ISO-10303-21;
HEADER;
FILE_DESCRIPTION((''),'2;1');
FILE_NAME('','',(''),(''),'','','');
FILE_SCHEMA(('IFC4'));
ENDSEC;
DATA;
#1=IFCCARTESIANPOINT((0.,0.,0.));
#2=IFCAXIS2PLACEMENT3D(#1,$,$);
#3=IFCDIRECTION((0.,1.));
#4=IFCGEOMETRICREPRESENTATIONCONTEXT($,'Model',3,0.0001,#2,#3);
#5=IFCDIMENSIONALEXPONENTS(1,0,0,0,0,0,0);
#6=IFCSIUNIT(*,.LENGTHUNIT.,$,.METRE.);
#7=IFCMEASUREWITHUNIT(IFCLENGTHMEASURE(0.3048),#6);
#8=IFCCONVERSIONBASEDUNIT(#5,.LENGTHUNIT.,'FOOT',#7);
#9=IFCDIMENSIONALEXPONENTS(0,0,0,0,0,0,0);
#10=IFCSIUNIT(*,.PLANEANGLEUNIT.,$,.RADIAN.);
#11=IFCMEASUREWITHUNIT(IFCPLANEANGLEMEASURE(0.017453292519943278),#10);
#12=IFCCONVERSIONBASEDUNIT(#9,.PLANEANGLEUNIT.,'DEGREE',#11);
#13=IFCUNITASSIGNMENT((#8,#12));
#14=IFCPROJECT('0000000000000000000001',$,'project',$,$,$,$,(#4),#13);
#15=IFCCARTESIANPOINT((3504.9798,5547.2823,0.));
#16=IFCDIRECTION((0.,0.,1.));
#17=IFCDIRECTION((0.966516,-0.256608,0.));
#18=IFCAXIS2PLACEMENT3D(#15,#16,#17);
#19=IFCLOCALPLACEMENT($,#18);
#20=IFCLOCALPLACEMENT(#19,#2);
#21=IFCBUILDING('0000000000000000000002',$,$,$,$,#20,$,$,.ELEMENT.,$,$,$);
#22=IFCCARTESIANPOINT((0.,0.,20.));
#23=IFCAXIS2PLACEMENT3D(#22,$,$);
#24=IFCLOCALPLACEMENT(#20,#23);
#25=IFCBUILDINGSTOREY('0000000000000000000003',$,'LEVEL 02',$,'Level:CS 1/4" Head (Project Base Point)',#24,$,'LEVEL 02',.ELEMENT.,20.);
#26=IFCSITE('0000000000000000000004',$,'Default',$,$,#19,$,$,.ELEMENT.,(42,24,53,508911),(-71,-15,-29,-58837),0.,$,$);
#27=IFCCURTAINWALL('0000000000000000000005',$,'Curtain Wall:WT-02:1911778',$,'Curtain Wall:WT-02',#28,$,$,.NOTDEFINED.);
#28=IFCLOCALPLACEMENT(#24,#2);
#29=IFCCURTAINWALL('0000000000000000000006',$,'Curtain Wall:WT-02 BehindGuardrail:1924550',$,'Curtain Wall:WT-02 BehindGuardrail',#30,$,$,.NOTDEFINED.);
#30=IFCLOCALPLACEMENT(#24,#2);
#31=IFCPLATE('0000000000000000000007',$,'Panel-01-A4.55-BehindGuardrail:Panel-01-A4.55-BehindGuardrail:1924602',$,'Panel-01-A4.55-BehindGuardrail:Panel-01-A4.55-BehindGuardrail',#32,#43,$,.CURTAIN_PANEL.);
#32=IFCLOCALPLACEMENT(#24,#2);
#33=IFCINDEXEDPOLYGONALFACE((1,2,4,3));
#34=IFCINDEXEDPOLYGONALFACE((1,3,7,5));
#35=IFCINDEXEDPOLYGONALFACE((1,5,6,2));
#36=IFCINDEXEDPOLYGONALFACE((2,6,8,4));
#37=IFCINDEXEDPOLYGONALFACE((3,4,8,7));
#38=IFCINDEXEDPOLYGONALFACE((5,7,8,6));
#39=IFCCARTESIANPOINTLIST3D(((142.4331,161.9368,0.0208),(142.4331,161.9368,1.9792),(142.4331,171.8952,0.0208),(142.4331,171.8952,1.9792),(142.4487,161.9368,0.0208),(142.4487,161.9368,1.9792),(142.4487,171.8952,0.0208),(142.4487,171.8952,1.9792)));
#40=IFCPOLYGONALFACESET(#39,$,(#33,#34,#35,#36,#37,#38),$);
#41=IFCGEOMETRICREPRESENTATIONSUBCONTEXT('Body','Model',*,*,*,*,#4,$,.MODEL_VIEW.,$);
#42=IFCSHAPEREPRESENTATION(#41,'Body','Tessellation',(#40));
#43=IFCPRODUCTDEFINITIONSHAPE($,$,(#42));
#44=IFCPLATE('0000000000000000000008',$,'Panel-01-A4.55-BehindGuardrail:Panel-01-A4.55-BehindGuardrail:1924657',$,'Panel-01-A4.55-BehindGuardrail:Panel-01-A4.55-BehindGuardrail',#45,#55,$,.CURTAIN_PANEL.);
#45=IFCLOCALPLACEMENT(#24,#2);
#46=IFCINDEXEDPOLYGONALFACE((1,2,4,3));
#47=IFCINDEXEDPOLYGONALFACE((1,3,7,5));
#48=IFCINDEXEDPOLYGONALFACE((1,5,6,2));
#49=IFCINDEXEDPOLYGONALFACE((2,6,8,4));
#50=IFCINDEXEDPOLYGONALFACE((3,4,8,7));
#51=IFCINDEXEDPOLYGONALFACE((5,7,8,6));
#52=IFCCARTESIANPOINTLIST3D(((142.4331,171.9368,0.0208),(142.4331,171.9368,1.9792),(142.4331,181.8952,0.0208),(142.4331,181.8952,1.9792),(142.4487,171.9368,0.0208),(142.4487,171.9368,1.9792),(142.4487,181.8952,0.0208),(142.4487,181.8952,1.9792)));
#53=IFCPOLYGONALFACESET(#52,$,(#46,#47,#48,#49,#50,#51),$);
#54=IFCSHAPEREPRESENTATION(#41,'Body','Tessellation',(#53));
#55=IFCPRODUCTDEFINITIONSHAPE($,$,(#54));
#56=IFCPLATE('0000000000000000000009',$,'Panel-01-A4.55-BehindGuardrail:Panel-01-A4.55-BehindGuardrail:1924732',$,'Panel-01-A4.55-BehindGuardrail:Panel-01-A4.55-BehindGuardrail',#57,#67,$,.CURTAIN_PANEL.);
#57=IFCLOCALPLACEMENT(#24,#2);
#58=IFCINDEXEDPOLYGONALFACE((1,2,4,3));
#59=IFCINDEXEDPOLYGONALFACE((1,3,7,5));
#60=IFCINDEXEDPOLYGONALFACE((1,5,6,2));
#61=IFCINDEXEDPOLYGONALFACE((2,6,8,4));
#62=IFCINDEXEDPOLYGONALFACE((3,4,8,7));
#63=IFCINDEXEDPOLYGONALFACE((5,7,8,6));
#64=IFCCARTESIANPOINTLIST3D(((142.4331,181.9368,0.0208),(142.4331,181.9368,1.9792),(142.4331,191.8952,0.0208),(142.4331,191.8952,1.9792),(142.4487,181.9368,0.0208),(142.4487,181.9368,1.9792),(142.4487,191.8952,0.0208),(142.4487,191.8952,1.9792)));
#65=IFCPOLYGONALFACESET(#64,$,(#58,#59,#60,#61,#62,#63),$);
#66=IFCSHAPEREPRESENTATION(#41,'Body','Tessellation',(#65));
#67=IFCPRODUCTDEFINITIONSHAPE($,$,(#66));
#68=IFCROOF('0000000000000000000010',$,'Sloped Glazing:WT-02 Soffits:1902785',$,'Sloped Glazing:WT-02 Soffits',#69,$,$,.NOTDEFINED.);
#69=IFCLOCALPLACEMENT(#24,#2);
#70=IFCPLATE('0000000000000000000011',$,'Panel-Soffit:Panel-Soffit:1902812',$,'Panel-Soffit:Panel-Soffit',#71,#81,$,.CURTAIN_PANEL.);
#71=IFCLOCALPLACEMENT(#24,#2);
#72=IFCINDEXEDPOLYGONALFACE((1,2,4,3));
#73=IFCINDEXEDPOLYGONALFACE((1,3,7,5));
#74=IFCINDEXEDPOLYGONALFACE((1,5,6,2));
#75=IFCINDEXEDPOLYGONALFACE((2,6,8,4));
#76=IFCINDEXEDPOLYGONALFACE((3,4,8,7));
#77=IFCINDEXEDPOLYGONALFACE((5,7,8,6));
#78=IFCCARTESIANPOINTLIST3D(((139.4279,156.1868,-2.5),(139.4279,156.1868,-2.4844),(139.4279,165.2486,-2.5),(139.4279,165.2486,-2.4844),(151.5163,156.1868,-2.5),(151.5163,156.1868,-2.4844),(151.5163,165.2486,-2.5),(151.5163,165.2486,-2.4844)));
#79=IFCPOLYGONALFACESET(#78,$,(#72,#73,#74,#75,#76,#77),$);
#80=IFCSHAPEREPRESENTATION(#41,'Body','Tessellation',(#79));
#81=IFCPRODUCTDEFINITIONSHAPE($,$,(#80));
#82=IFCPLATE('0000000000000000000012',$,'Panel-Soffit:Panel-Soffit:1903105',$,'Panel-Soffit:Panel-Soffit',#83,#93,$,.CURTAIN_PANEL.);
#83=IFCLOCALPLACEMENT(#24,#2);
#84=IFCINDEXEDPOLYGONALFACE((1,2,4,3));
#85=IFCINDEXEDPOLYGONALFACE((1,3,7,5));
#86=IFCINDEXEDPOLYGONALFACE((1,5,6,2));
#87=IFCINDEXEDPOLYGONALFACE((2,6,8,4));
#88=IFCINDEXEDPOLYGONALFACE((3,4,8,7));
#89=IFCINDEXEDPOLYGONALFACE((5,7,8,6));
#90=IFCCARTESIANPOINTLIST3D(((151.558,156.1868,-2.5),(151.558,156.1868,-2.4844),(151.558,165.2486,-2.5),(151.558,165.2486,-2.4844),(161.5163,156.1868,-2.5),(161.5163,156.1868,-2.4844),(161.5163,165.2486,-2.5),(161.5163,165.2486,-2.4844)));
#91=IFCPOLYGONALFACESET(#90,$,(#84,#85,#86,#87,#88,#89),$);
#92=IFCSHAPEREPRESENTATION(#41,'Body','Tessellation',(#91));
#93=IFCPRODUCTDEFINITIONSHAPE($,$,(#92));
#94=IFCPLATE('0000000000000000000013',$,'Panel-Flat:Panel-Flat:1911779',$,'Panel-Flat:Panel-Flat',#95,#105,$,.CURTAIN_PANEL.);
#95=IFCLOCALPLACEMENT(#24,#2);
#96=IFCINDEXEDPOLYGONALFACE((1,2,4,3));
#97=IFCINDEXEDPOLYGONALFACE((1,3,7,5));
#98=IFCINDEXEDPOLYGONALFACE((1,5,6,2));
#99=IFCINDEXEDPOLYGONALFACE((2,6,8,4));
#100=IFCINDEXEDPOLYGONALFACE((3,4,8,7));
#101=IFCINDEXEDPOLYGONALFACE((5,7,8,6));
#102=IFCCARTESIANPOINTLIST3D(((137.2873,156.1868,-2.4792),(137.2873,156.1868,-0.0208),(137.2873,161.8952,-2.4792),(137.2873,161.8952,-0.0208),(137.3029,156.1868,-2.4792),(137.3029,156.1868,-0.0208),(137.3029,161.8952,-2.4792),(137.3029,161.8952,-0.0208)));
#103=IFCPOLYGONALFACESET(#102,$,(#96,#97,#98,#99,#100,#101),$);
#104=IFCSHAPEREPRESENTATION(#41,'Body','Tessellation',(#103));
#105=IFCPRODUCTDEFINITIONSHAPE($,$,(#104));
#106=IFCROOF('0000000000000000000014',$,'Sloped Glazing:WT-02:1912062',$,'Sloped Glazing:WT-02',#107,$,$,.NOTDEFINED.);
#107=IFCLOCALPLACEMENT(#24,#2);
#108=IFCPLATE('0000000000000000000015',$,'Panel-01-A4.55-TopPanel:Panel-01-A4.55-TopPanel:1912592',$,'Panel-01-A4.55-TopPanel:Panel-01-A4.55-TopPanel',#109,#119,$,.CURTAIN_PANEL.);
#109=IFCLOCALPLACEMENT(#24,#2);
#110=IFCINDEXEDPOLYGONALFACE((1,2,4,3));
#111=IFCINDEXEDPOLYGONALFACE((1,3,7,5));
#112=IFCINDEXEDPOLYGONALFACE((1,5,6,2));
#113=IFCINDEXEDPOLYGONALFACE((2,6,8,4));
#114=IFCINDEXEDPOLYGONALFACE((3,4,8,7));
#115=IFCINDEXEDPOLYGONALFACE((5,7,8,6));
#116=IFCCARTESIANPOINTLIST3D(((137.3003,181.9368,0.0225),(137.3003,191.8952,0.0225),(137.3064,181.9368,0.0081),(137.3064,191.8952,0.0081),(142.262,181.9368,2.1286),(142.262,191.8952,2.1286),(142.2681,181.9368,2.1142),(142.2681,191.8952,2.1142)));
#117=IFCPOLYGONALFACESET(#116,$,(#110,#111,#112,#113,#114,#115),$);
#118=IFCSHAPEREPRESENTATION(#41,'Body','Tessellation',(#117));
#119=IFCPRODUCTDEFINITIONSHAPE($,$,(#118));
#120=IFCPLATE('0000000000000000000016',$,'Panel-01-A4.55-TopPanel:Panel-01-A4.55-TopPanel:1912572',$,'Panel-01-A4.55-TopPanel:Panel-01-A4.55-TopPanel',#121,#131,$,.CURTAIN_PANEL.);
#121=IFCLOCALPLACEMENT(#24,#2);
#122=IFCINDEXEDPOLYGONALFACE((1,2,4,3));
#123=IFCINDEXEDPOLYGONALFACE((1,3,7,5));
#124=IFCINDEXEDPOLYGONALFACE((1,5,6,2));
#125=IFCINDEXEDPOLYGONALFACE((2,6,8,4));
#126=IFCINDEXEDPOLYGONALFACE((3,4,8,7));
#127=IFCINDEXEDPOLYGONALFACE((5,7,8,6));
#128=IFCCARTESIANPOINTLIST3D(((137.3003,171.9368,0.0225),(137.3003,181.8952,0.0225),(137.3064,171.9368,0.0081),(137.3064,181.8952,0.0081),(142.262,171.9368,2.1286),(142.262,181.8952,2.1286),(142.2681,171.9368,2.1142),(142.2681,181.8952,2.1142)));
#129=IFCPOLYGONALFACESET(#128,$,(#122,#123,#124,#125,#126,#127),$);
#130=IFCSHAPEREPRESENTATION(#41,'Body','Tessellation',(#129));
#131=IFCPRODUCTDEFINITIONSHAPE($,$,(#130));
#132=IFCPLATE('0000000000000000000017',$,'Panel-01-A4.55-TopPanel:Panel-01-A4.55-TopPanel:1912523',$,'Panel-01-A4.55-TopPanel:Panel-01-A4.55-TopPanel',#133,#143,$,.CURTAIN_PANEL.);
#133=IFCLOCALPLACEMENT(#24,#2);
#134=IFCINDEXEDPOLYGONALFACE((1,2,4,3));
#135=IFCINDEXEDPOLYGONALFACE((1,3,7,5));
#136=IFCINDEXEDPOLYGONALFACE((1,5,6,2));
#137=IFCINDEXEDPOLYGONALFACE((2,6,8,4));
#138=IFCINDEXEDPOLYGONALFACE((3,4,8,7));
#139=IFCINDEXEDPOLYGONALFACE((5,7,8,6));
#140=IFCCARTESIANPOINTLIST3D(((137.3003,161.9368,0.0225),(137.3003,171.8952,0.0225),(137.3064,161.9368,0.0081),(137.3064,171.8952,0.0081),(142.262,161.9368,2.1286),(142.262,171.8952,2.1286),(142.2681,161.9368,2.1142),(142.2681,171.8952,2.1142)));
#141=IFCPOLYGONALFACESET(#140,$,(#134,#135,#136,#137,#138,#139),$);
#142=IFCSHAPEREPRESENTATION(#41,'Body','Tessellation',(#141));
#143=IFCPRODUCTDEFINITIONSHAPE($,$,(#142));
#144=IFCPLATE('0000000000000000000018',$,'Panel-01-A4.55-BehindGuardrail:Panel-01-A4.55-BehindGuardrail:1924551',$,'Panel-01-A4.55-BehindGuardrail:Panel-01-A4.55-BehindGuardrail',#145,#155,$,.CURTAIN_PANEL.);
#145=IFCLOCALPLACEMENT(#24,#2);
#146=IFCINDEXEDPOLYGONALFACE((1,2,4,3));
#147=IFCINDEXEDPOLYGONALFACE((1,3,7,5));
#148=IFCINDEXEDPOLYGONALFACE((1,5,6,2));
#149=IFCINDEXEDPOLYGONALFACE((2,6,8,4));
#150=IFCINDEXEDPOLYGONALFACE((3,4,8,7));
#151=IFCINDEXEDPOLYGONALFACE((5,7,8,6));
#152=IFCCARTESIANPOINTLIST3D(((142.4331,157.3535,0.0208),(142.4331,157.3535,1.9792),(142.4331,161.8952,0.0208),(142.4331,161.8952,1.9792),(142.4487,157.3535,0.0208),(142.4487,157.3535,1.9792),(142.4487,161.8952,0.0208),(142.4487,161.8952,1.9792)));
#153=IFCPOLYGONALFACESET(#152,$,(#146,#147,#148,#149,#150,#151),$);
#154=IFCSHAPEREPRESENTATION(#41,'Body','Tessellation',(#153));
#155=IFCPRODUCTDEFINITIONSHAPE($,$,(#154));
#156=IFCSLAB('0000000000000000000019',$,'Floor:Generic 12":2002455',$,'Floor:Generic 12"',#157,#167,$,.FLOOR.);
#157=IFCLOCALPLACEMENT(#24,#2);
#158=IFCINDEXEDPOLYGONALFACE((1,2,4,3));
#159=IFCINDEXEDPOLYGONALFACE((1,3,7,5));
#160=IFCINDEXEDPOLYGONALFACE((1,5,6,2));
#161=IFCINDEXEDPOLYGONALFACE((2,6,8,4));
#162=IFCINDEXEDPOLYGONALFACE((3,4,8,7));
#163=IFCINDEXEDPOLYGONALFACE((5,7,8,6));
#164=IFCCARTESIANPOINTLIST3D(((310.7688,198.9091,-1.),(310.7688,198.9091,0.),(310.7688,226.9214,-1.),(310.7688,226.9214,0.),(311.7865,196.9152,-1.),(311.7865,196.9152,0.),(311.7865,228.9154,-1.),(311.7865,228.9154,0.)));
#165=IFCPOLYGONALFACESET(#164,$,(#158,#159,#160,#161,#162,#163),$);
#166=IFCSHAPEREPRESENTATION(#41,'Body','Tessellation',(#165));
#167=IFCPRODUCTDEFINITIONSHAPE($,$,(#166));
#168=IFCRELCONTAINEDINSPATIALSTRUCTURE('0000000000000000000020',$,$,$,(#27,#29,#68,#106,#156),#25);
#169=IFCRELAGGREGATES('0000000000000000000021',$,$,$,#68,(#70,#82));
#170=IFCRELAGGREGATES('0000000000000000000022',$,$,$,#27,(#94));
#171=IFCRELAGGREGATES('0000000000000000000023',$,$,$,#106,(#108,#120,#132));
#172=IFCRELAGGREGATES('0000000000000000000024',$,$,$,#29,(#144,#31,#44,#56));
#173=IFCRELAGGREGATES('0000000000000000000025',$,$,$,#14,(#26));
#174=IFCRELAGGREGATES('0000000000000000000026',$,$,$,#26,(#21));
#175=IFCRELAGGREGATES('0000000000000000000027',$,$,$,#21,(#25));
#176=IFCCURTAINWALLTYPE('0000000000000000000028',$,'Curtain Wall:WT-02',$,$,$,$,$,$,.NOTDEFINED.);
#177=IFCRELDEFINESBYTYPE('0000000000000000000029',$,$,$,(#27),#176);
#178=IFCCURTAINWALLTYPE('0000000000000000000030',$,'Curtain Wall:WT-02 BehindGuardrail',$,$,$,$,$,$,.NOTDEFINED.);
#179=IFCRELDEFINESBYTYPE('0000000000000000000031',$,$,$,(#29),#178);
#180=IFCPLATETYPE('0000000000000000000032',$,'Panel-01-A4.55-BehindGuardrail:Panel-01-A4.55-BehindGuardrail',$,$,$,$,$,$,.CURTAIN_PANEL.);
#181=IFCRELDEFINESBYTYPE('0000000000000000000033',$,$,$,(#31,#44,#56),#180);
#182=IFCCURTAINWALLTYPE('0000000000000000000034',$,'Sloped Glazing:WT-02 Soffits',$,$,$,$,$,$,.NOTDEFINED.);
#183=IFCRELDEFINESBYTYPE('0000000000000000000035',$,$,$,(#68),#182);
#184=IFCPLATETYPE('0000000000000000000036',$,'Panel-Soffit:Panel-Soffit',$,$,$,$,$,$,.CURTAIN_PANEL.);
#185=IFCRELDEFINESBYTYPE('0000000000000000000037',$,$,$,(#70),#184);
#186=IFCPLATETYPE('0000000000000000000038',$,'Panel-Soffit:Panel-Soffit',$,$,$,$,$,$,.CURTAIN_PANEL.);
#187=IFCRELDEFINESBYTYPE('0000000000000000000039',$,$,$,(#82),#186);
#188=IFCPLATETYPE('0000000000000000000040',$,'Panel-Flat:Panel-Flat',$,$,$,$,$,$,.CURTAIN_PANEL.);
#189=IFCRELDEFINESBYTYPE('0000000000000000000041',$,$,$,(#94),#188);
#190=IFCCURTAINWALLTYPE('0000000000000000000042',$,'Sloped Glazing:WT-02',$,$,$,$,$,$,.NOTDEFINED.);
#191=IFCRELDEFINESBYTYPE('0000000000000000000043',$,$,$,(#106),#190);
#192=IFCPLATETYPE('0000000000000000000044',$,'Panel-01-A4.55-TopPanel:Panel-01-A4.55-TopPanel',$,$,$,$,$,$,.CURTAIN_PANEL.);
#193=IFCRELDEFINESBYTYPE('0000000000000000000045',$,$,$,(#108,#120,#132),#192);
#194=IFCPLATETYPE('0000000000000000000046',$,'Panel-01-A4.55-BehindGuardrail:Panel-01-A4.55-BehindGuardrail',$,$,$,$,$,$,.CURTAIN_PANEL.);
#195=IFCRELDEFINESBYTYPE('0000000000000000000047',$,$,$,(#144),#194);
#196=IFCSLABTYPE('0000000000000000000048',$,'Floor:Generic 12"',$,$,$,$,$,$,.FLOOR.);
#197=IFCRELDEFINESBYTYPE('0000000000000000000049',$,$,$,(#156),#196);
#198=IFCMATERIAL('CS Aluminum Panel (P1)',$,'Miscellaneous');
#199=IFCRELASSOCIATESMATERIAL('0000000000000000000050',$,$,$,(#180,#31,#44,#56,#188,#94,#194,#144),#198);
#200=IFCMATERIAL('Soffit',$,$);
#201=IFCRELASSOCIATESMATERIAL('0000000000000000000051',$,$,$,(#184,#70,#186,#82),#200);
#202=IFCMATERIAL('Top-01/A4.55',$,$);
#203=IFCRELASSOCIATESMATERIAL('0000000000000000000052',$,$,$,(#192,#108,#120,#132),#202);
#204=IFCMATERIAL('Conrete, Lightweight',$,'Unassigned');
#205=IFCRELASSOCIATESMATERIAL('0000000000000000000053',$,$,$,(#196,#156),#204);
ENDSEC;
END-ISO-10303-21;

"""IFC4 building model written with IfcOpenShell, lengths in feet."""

from ifc_helpers import new_model, entity, si_unit, converted_unit, direction, frame, origin, place, context, subcontext, project, spatial, indexed_curve, outline, extrude, source, transform, mapped, material, type_object, type_shapes, element, aggregate, save


model = new_model("IFC4")

# Units and contexts
model_context = context("Model", 3, precision=0.0001, world=origin(), true_north=direction((0.0, 1.0)))
body_context = subcontext(model_context, "Body", "Model", "MODEL_VIEW")
ifc_project = project(units=[converted_unit("LENGTHUNIT", "FOOT", entity("IfcLengthMeasure", 0.3048), si_unit("LENGTHUNIT", "METRE"), dimensions=[1, 0, 0, 0, 0, 0, 0]), converted_unit("PLANEANGLEUNIT", "DEGREE", entity("IfcPlaneAngleMeasure", 0.017453292519943278), si_unit("PLANEANGLEUNIT", "RADIAN"), dimensions=[0, 0, 0, 0, 0, 0, 0])], contexts=[model_context])

# Site, building, storey
site_placement = place(None, frame((3504.9798, 5547.2823, 0.0), z_axis=(0.0, 0.0, 1.0), x_axis=(0.966516, -0.256608, 0.0)))
site = spatial("IfcSite", under=ifc_project, at=site_placement, Name="Default", CompositionType="ELEMENT", RefLatitude=(42, 24, 53, 508911), RefLongitude=(-71, -15, -29, -58837), RefElevation=0.0)
building_placement = place(site_placement, origin())
building = spatial("IfcBuilding", under=site, at=building_placement, CompositionType="ELEMENT")
storey_placement = place(building_placement, frame((0.0, 0.0, 20.0)))
storey = spatial("IfcBuildingStorey", under=building, at=storey_placement, Name="LEVEL 02", ObjectType="Level:CS 1/4\" Head (Project Base Point)", LongName="LEVEL 02", CompositionType="ELEMENT", Elevation=20.0)

# Curtain wall
curtain_wall_type_1 = type_object("IfcCurtainWallType", Name="Curtain Wall:WT-02", PredefinedType="NOTDEFINED")
ifc_material_1 = material(Name="CS Aluminum Panel (P1)", Category="Miscellaneous")
curtain_wall_1_placement = place(storey_placement, frame((0.0, 0.0, -20.0)))
curtain_wall_1 = element("IfcCurtainWall", 1, at=curtain_wall_1_placement, inside=storey, type_object=curtain_wall_type_1, Name="Curtain Wall:WT-02:1911778", ObjectType="Curtain Wall:WT-02", PredefinedType="NOTDEFINED")

# Curtain wall, plates
ifc_material_2 = material(Name="Top-01/A4.55")
curtain_wall_type_2 = type_object("IfcCurtainWallType", Name="Curtain Wall:WT-02 BehindGuardrail", PredefinedType="NOTDEFINED")
plate_type_1 = type_object("IfcPlateType", Name="Panel-01-A4.55-BehindGuardrail:Panel-01-A4.55-BehindGuardrail", PredefinedType="CURTAIN_PANEL", material=ifc_material_1)
shared_shape_1 = source(origin(), body_context, "Body", "SweptSolid", [
    extrude(outline(indexed_curve([(-0.0078, -4.9792), (0.0078, -4.9792), (0.0078, 4.9792), (-0.0078, 4.9792), (-0.0078, -4.9792)], self_intersect=False)), frame((0.0, -0.0078, 0.0208), z_axis=(0.0, 0.0, 1.0), x_axis=(0.0, -1.0, 0.0)), (0.0, 0.0, 1.0), 1.9583),
])
type_shapes(plate_type_1, [shared_shape_1])
curtain_wall_2_placement = place(storey_placement, frame((0.0, 0.0, -20.0)))
curtain_wall_2 = element("IfcCurtainWall", 2, at=curtain_wall_2_placement, inside=storey, type_object=curtain_wall_type_2, Name="Curtain Wall:WT-02 BehindGuardrail:1924550", ObjectType="Curtain Wall:WT-02 BehindGuardrail", PredefinedType="NOTDEFINED")
plate_1_placement = place(curtain_wall_2_placement, frame((142.4331, 166.916, 20.0), z_axis=(0.0, 0.0, 1.0), x_axis=(0.0, 1.0, 0.0)))
plate_1 = element("IfcPlate", 3, at=plate_1_placement, type_object=plate_type_1, material=ifc_material_1, Name="Panel-01-A4.55-BehindGuardrail:Panel-01-A4.55-BehindGuardrail:1924602", ObjectType="Panel-01-A4.55-BehindGuardrail:Panel-01-A4.55-BehindGuardrail", PredefinedType="CURTAIN_PANEL", context=body_context, shape_type="MappedRepresentation", body=[
    mapped(shared_shape_1, transform((0.0, 0.0, 0.0), scale=1.0)),
])
plate_2_placement = place(curtain_wall_2_placement, frame((142.4331, 176.916, 20.0), z_axis=(0.0, 0.0, 1.0), x_axis=(0.0, 1.0, 0.0)))
plate_2 = element("IfcPlate", 4, at=plate_2_placement, type_object=plate_type_1, material=ifc_material_1, Name="Panel-01-A4.55-BehindGuardrail:Panel-01-A4.55-BehindGuardrail:1924657", ObjectType="Panel-01-A4.55-BehindGuardrail:Panel-01-A4.55-BehindGuardrail", PredefinedType="CURTAIN_PANEL", context=body_context, shape_type="MappedRepresentation", body=[
    mapped(shared_shape_1, transform((0.0, 0.0, 0.0), scale=1.0)),
])
plate_3_placement = place(curtain_wall_2_placement, frame((142.4331, 186.916, 20.0), z_axis=(0.0, 0.0, 1.0), x_axis=(0.0, 1.0, 0.0)))
plate_3 = element("IfcPlate", 5, at=plate_3_placement, type_object=plate_type_1, material=ifc_material_1, Name="Panel-01-A4.55-BehindGuardrail:Panel-01-A4.55-BehindGuardrail:1924732", ObjectType="Panel-01-A4.55-BehindGuardrail:Panel-01-A4.55-BehindGuardrail", PredefinedType="CURTAIN_PANEL", context=body_context, shape_type="MappedRepresentation", body=[
    mapped(shared_shape_1, transform((0.0, 0.0, 0.0), scale=1.0)),
])

# Roof, plates
curtain_wall_type_3 = type_object("IfcCurtainWallType", Name="Sloped Glazing:WT-02 Soffits", PredefinedType="NOTDEFINED")
roof_1_placement = place(storey_placement, frame((0.0, 0.0, -20.0)))
roof_1 = element("IfcRoof", 6, at=roof_1_placement, inside=storey, type_object=curtain_wall_type_3, Name="Sloped Glazing:WT-02 Soffits:1902785", ObjectType="Sloped Glazing:WT-02 Soffits", PredefinedType="NOTDEFINED")
ifc_material_3 = material(Name="Soffit")
plate_type_2 = type_object("IfcPlateType", Name="Panel-Soffit:Panel-Soffit", PredefinedType="CURTAIN_PANEL", material=ifc_material_3)
shared_shape_2 = source(origin(), body_context, "Body", "SweptSolid", [
    extrude(outline(indexed_curve([(-0.0078, -6.0442), (0.0078, -6.0442), (0.0078, 6.0442), (-0.0078, 6.0442), (-0.0078, -6.0442)], self_intersect=False)), frame((0.0, -0.0078, 0.0208), z_axis=(0.0, 0.0, 1.0), x_axis=(0.0, -1.0, 0.0)), (0.0, 0.0, 1.0), 9.0617),
])
type_shapes(plate_type_2, [shared_shape_2])
plate_4_placement = place(roof_1_placement, frame((145.4721, 156.166, 17.5), z_axis=(0.0, 1.0, 0.0), x_axis=(1.0, 0.0, 0.0)))
plate_4 = element("IfcPlate", 7, at=plate_4_placement, type_object=plate_type_2, material=ifc_material_3, Name="Panel-Soffit:Panel-Soffit:1902812", ObjectType="Panel-Soffit:Panel-Soffit", PredefinedType="CURTAIN_PANEL", context=body_context, shape_type="MappedRepresentation", body=[
    mapped(shared_shape_2, transform((0.0, 0.0, 0.0), scale=1.0)),
])
plate_type_3 = type_object("IfcPlateType", Name="Panel-Soffit:Panel-Soffit", PredefinedType="CURTAIN_PANEL", material=ifc_material_3)
shared_shape_3 = source(origin(), body_context, "Body", "SweptSolid", [
    extrude(outline(indexed_curve([(-0.0078, -4.9792), (0.0078, -4.9792), (0.0078, 4.9792), (-0.0078, 4.9792), (-0.0078, -4.9792)], self_intersect=False)), frame((0.0, -0.0078, 0.0208), z_axis=(0.0, 0.0, 1.0), x_axis=(0.0, -1.0, 0.0)), (0.0, 0.0, 1.0), 9.0617),
])
type_shapes(plate_type_3, [shared_shape_3])
plate_5_placement = place(roof_1_placement, frame((156.5372, 156.166, 17.5), z_axis=(0.0, 1.0, 0.0), x_axis=(1.0, 0.0, 0.0)))
plate_5 = element("IfcPlate", 8, at=plate_5_placement, type_object=plate_type_3, material=ifc_material_3, Name="Panel-Soffit:Panel-Soffit:1903105", ObjectType="Panel-Soffit:Panel-Soffit", PredefinedType="CURTAIN_PANEL", context=body_context, shape_type="MappedRepresentation", body=[
    mapped(shared_shape_3, transform((0.0, 0.0, 0.0), scale=1.0)),
])
aggregate(roof_1, [plate_4, plate_5])

# Plate
plate_type_4 = type_object("IfcPlateType", Name="Panel-Flat:Panel-Flat", PredefinedType="CURTAIN_PANEL", material=ifc_material_1)
shared_shape_4 = source(origin(), body_context, "Body", "SweptSolid", [
    extrude(outline(indexed_curve([(-0.0078, -2.8542), (0.0078, -2.8542), (0.0078, 2.8542), (-0.0078, 2.8542), (-0.0078, -2.8542)], self_intersect=False)), frame((0.0, -0.0078, 0.0208), z_axis=(0.0, 0.0, 1.0), x_axis=(0.0, -1.0, 0.0)), (0.0, 0.0, 1.0), 2.4583),
])
type_shapes(plate_type_4, [shared_shape_4])
plate_6_placement = place(curtain_wall_1_placement, frame((137.2873, 159.041, 17.5), z_axis=(0.0, 0.0, 1.0), x_axis=(0.0, 1.0, 0.0)))
plate_6 = element("IfcPlate", 9, at=plate_6_placement, type_object=plate_type_4, material=ifc_material_1, Name="Panel-Flat:Panel-Flat:1911779", ObjectType="Panel-Flat:Panel-Flat", PredefinedType="CURTAIN_PANEL", context=body_context, shape_type="MappedRepresentation", body=[
    mapped(shared_shape_4, transform((0.0, 0.0, 0.0), scale=1.0)),
])
aggregate(curtain_wall_1, [plate_6])

# Roof, plates
curtain_wall_type_4 = type_object("IfcCurtainWallType", Name="Sloped Glazing:WT-02", PredefinedType="NOTDEFINED")
roof_2_placement = place(storey_placement, frame((0.0, 0.0, -20.0)))
roof_2 = element("IfcRoof", 10, at=roof_2_placement, inside=storey, type_object=curtain_wall_type_4, Name="Sloped Glazing:WT-02:1912062", ObjectType="Sloped Glazing:WT-02", PredefinedType="NOTDEFINED")
plate_type_5 = type_object("IfcPlateType", Name="Panel-01-A4.55-TopPanel:Panel-01-A4.55-TopPanel", PredefinedType="CURTAIN_PANEL", material=ifc_material_2)
shared_shape_5 = source(origin(), body_context, "Body", "SweptSolid", [
    extrude(outline(indexed_curve([(-0.0078, -4.9792), (0.0078, -4.9792), (0.0078, 4.9792), (-0.0078, 4.9792), (-0.0078, -4.9792)], self_intersect=False)), frame((0.0, -0.0078, 0.0208), z_axis=(0.0, 0.0, 1.0), x_axis=(0.0, -1.0, 0.0)), (0.0, 0.0, 1.0), 5.3901),
])
type_shapes(plate_type_5, [shared_shape_5])
plate_7_placement = place(roof_2_placement, frame((137.2873, 186.916, 20.0), z_axis=(0.920505, 0.0, 0.390731), x_axis=(0.0, -1.0, 0.0)))
plate_7 = element("IfcPlate", 11, at=plate_7_placement, type_object=plate_type_5, material=ifc_material_2, Name="Panel-01-A4.55-TopPanel:Panel-01-A4.55-TopPanel:1912592", ObjectType="Panel-01-A4.55-TopPanel:Panel-01-A4.55-TopPanel", PredefinedType="CURTAIN_PANEL", context=body_context, shape_type="MappedRepresentation", body=[
    mapped(shared_shape_5, transform((0.0, 0.0, 0.0), scale=1.0)),
])
plate_8_placement = place(roof_2_placement, frame((137.2873, 176.916, 20.0), z_axis=(0.920505, 0.0, 0.390731), x_axis=(0.0, -1.0, 0.0)))
plate_8 = element("IfcPlate", 12, at=plate_8_placement, type_object=plate_type_5, material=ifc_material_2, Name="Panel-01-A4.55-TopPanel:Panel-01-A4.55-TopPanel:1912572", ObjectType="Panel-01-A4.55-TopPanel:Panel-01-A4.55-TopPanel", PredefinedType="CURTAIN_PANEL", context=body_context, shape_type="MappedRepresentation", body=[
    mapped(shared_shape_5, transform((0.0, 0.0, 0.0), scale=1.0)),
])
plate_9_placement = place(roof_2_placement, frame((137.2873, 166.916, 20.0), z_axis=(0.920505, 0.0, 0.390731), x_axis=(0.0, -1.0, 0.0)))
plate_9 = element("IfcPlate", 13, at=plate_9_placement, type_object=plate_type_5, material=ifc_material_2, Name="Panel-01-A4.55-TopPanel:Panel-01-A4.55-TopPanel:1912523", ObjectType="Panel-01-A4.55-TopPanel:Panel-01-A4.55-TopPanel", PredefinedType="CURTAIN_PANEL", context=body_context, shape_type="MappedRepresentation", body=[
    mapped(shared_shape_5, transform((0.0, 0.0, 0.0), scale=1.0)),
])
aggregate(roof_2, [plate_7, plate_8, plate_9])

# Plate
plate_type_6 = type_object("IfcPlateType", Name="Panel-01-A4.55-BehindGuardrail:Panel-01-A4.55-BehindGuardrail", PredefinedType="CURTAIN_PANEL", material=ifc_material_1)
shared_shape_6 = source(origin(), body_context, "Body", "SweptSolid", [
    extrude(outline(indexed_curve([(-0.0078, -2.2708), (0.0078, -2.2708), (0.0078, 2.2708), (-0.0078, 2.2708), (-0.0078, -2.2708)], self_intersect=False)), frame((0.0, -0.0078, 0.0208), z_axis=(0.0, 0.0, 1.0), x_axis=(0.0, -1.0, 0.0)), (0.0, 0.0, 1.0), 1.9583),
])
type_shapes(plate_type_6, [shared_shape_6])
plate_10_placement = place(curtain_wall_2_placement, frame((142.4331, 159.6243, 20.0), z_axis=(0.0, 0.0, 1.0), x_axis=(0.0, 1.0, 0.0)))
plate_10 = element("IfcPlate", 14, at=plate_10_placement, type_object=plate_type_6, material=ifc_material_1, Name="Panel-01-A4.55-BehindGuardrail:Panel-01-A4.55-BehindGuardrail:1924551", ObjectType="Panel-01-A4.55-BehindGuardrail:Panel-01-A4.55-BehindGuardrail", PredefinedType="CURTAIN_PANEL", context=body_context, shape_type="MappedRepresentation", body=[
    mapped(shared_shape_6, transform((0.0, 0.0, 0.0), scale=1.0)),
])
aggregate(curtain_wall_2, [plate_10, plate_1, plate_2, plate_3])

# Shared definitions
ifc_material_4 = material(Name="Conrete, Lightweight", Category="Unassigned")
slab_type = type_object("IfcSlabType", Name="Floor:Generic 12\"", PredefinedType="FLOOR", material=ifc_material_4)

# Slab
slab_1_placement = place(storey_placement, origin())
element("IfcSlab", 15, at=slab_1_placement, inside=storey, type_object=slab_type, material=ifc_material_4, Name="Floor:Generic 12\":2002455", ObjectType="Floor:Generic 12\"", PredefinedType="FLOOR", context=body_context, shape_type="SweptSolid", body=[
    extrude(outline(indexed_curve([(-14.0061, -0.5089), (14.0061, -0.5089), (16.0001, 0.5089), (-16.0001, 0.5089), (-14.0061, -0.5089)], self_intersect=False)), frame((311.2776, 212.9153, 0.0), z_axis=(0.0, 0.0, -1.0), x_axis=(0.0, 1.0, 0.0)), (0.0, 0.0, 1.0), 1.0),
])

save(model, "model.ifc")
